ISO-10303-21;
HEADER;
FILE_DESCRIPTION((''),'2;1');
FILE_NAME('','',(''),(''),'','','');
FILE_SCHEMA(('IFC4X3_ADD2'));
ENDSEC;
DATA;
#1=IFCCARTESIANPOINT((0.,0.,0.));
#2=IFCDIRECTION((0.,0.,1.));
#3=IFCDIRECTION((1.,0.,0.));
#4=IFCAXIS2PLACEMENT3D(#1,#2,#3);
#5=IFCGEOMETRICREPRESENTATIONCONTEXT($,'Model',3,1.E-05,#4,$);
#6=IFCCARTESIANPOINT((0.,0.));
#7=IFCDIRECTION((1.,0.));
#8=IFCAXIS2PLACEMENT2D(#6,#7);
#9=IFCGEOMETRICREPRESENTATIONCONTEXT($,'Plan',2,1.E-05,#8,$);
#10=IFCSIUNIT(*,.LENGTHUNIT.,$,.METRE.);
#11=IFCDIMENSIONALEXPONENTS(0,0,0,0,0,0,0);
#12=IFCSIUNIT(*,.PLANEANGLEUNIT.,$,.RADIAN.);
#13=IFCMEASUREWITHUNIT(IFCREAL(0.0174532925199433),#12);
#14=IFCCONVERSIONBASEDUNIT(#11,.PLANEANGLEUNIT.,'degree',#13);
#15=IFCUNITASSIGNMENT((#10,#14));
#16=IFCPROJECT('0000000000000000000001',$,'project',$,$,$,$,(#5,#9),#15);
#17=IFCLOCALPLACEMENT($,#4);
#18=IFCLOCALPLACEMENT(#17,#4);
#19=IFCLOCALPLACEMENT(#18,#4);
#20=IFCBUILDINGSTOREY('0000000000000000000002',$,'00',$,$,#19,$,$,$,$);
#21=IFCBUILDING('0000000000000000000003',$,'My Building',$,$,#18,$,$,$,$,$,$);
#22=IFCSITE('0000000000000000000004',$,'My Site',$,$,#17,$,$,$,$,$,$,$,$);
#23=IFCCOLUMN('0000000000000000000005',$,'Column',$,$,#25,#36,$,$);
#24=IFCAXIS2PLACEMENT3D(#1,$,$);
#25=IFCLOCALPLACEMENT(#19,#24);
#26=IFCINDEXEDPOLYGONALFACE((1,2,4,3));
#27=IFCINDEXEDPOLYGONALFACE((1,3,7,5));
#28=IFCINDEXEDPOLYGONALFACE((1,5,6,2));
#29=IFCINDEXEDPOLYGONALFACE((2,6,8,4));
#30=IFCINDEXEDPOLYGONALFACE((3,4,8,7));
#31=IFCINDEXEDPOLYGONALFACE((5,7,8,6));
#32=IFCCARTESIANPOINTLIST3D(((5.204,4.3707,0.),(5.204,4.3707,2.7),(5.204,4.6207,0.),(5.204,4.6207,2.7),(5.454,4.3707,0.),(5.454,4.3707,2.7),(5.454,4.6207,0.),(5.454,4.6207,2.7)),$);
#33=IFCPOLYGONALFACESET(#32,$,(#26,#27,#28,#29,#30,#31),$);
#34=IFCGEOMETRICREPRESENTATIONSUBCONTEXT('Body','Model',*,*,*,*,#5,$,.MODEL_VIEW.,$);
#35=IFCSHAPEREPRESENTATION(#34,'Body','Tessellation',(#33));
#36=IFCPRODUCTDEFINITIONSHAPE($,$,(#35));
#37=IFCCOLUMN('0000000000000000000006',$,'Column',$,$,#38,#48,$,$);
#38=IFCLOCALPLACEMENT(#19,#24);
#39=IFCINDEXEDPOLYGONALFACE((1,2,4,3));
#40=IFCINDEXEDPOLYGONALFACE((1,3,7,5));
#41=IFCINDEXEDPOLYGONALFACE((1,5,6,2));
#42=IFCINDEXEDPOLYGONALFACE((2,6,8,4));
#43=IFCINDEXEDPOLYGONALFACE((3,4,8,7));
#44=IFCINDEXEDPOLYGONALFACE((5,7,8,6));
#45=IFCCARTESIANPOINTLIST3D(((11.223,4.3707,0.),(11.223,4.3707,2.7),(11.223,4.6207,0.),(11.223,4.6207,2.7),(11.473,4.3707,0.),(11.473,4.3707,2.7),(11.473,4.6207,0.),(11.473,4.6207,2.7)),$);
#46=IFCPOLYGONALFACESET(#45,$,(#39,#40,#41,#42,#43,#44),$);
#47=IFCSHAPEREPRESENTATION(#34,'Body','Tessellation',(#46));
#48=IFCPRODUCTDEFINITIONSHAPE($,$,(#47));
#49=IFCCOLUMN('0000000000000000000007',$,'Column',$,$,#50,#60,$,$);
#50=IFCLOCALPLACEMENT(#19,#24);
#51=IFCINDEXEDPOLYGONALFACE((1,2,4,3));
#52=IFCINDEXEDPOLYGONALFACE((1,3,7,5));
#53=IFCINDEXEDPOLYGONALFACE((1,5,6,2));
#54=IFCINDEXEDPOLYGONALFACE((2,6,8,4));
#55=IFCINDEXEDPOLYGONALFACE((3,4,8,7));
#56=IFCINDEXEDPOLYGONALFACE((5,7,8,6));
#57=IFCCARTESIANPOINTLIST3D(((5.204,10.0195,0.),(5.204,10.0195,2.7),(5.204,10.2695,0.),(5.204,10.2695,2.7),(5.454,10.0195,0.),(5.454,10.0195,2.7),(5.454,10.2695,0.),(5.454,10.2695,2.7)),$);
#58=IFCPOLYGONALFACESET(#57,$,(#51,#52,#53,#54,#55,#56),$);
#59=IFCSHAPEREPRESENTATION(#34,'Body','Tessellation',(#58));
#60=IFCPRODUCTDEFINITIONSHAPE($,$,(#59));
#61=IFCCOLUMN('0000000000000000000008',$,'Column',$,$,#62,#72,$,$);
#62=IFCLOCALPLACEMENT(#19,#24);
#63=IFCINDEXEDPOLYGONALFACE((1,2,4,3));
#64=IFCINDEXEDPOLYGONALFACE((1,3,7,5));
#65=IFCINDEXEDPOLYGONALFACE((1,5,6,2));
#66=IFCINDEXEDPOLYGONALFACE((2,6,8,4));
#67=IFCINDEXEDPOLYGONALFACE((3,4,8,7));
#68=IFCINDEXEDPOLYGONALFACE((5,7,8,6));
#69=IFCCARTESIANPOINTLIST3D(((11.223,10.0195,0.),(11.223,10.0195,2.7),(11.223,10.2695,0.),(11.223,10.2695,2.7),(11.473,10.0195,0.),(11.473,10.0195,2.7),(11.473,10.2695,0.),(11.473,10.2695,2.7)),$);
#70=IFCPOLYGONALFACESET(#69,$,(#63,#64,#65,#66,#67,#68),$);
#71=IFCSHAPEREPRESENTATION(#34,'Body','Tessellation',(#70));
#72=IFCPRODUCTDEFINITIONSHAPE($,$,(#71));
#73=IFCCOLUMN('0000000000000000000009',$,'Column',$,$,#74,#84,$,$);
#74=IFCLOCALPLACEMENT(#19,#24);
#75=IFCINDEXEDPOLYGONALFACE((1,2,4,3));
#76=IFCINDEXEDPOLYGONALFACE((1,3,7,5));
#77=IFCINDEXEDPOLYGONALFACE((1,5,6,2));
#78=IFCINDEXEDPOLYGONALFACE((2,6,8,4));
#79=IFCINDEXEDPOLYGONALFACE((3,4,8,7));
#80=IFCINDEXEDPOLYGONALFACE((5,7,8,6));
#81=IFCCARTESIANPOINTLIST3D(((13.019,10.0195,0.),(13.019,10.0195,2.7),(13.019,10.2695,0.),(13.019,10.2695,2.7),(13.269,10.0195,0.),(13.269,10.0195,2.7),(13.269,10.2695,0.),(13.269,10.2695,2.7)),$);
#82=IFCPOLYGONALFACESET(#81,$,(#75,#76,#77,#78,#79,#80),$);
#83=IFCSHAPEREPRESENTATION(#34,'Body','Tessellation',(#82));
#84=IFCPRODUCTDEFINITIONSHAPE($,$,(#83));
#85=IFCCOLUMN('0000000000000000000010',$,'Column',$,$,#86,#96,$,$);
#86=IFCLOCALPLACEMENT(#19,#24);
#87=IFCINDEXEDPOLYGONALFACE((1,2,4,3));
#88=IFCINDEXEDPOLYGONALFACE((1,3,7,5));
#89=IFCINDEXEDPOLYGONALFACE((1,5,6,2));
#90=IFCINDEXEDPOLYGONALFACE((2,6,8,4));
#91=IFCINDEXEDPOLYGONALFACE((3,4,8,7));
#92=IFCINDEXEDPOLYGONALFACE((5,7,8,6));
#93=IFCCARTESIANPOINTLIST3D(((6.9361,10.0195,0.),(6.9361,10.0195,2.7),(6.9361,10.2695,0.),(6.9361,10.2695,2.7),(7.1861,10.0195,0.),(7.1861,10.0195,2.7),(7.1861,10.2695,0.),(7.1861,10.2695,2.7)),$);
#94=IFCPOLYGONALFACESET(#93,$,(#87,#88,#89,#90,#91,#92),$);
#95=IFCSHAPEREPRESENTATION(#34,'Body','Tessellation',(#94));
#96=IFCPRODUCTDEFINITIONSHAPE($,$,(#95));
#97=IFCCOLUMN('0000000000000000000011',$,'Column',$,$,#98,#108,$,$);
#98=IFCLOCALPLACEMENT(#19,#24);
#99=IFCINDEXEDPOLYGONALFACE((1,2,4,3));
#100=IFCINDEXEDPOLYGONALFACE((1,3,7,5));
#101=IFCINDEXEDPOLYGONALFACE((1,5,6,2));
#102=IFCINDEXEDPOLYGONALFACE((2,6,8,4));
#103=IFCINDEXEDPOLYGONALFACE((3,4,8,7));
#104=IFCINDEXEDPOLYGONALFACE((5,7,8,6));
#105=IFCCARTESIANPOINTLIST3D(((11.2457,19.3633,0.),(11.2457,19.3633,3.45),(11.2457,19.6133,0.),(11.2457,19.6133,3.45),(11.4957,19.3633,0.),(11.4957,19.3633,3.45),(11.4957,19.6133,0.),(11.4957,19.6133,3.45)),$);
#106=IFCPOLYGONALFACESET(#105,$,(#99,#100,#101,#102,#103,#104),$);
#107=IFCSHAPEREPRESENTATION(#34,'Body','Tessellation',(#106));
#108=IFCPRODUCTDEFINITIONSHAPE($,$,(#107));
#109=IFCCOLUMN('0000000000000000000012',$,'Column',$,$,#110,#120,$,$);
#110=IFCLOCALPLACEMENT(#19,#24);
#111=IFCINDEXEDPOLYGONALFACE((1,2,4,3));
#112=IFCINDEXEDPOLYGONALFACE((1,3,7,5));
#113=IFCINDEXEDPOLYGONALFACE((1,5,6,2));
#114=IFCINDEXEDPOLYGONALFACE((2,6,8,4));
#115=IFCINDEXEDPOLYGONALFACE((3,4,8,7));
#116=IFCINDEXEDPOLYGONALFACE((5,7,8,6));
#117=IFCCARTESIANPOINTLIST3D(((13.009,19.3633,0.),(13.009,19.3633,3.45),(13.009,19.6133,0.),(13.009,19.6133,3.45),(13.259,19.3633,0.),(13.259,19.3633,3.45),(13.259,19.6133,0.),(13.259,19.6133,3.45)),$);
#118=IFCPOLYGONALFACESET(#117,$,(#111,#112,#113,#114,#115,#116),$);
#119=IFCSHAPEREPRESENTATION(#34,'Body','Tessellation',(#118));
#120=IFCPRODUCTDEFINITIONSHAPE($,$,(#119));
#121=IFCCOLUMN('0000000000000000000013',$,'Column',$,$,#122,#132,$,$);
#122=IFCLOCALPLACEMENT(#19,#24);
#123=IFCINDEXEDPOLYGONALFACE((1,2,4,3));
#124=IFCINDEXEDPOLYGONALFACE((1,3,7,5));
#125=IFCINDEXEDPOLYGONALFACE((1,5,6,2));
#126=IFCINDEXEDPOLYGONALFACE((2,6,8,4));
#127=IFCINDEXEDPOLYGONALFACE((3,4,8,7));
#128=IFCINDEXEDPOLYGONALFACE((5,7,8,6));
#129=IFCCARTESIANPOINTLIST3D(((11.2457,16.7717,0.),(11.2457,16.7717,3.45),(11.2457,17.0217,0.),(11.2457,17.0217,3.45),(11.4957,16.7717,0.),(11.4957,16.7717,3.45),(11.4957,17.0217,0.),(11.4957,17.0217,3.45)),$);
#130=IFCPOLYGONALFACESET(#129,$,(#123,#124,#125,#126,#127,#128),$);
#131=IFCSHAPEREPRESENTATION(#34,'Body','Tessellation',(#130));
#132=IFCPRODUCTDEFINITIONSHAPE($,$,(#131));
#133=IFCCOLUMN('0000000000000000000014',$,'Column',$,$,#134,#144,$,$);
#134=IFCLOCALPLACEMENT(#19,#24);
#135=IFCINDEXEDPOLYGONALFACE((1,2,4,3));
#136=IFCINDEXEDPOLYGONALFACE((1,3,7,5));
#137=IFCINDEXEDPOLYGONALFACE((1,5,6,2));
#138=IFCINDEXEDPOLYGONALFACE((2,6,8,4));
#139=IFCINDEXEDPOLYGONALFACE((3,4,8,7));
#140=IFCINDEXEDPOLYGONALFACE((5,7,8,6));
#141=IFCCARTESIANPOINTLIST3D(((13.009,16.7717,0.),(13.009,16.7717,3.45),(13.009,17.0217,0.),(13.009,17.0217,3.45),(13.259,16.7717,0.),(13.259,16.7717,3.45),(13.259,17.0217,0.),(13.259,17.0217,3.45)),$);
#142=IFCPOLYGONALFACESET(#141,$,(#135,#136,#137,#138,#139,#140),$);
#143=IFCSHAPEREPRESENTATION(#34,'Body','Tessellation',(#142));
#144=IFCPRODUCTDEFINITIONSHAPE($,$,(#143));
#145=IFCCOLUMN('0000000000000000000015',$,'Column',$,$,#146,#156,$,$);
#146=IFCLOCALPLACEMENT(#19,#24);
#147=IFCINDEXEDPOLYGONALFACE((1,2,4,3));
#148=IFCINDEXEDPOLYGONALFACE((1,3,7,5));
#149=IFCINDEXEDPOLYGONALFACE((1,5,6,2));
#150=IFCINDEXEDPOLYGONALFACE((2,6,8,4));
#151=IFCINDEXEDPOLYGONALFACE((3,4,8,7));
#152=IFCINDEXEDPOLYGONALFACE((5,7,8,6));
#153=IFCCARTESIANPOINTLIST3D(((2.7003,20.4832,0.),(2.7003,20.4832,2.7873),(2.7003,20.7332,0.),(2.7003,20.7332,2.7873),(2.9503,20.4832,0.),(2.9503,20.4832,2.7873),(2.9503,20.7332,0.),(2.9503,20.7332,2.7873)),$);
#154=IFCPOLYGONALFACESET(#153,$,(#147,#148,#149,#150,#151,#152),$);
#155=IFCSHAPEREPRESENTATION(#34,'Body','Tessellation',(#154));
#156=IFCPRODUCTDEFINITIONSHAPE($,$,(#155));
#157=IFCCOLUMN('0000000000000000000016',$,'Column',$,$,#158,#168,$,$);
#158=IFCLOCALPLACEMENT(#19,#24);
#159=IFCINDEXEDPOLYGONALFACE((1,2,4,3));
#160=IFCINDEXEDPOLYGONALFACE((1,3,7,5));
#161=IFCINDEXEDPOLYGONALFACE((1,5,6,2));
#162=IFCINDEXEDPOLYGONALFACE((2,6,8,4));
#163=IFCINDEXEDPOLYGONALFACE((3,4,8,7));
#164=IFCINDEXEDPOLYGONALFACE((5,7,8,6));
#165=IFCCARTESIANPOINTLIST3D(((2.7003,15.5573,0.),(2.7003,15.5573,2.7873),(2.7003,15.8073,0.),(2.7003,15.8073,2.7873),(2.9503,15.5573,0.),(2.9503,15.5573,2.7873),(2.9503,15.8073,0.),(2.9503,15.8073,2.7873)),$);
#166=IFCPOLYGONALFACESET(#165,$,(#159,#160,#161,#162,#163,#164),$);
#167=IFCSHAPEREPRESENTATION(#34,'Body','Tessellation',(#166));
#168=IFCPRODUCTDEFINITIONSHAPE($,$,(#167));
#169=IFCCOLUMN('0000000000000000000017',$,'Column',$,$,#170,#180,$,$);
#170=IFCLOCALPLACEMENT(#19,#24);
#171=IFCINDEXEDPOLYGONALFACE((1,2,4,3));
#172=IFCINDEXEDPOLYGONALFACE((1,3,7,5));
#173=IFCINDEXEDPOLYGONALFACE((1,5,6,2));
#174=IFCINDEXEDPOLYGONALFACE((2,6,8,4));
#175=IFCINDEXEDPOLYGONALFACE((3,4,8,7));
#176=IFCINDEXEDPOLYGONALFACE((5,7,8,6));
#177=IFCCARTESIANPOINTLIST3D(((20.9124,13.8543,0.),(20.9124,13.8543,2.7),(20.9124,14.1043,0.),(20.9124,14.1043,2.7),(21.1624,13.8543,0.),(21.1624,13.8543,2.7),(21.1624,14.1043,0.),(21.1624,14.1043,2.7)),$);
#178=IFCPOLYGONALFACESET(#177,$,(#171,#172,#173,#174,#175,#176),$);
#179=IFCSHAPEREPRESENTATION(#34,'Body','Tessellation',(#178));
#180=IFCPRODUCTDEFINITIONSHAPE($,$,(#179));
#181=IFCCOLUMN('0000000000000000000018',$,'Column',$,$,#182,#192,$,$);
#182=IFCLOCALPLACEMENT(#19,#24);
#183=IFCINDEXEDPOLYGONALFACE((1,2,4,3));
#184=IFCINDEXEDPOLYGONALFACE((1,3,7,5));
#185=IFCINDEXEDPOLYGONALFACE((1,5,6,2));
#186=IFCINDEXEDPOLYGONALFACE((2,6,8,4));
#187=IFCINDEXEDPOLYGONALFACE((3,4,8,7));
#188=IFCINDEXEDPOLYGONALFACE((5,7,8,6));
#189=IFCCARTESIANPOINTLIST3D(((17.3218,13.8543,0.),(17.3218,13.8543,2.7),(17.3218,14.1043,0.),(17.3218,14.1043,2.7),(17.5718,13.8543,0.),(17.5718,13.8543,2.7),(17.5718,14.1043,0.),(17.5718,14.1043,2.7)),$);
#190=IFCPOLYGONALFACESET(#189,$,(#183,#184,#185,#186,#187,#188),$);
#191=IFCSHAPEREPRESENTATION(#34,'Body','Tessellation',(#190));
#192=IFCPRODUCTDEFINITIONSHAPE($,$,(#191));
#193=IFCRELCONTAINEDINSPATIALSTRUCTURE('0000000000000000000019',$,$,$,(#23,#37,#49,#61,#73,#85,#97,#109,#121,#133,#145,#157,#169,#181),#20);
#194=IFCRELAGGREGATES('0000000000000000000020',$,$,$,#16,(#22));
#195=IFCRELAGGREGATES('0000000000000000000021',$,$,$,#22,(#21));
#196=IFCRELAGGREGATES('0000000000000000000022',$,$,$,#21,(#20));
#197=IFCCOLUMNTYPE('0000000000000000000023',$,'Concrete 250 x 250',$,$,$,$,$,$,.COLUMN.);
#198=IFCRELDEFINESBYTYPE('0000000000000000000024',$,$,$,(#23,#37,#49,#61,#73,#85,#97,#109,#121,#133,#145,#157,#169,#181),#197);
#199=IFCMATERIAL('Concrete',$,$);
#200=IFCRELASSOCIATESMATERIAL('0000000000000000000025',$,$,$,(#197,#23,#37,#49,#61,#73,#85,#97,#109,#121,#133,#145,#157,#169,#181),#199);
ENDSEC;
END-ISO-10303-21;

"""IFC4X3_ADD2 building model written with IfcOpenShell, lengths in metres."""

from ifc_helpers import new_model, entity, si_unit, converted_unit, frame, origin_with_axes, origin_2d_with_axis, place, context, subcontext, project, spatial, rectangle, extrude, material, material_profile, profile_set, profile_usage, type_object, element, save


model = new_model("IFC4X3_ADD2")

# Units and contexts
model_context = context("Model", 3, precision=1e-05, world=origin_with_axes())
plan_context = context("Plan", 2, precision=1e-05, world=origin_2d_with_axis())
body_context = subcontext(model_context, "Body", "Model", "MODEL_VIEW")
ifc_project = project(units=[si_unit("LENGTHUNIT", "METRE"), converted_unit("PLANEANGLEUNIT", "degree", entity("IfcReal", 0.0174532925199433), si_unit("PLANEANGLEUNIT", "RADIAN"), dimensions=[0, 0, 0, 0, 0, 0, 0])], contexts=[model_context, plan_context])

# Site, building, storey
site_placement = place(None, origin_with_axes())
site = spatial("IfcSite", under=ifc_project, at=site_placement, Name="My Site")
building_placement = place(site_placement, origin_with_axes())
building = spatial("IfcBuilding", under=site, at=building_placement, Name="My Building")
storey_placement = place(building_placement, origin_with_axes())
storey = spatial("IfcBuildingStorey", under=building, at=storey_placement, Name="00")

# Columns
ifc_material_1 = material(Name="Concrete")
ifc_material_profile = material_profile(ifc_material_1, rectangle(XDim=0.25, YDim=0.25))
ifc_profile_set = profile_set([ifc_material_profile])
ifc_profile_usage_1 = profile_usage(ifc_profile_set, cardinal=5)
column_type = type_object("IfcColumnType", Name="Concrete 250 x 250", PredefinedType="COLUMN", material=ifc_profile_set)
column_1_placement = place(storey_placement, frame((5.329, 4.4957, 0.0), z_axis=(0.0, 0.0, 1.0), x_axis=(1.0, 0.0, 0.0)))
element("IfcColumn", 1, at=column_1_placement, inside=storey, type_object=column_type, material=ifc_profile_usage_1, Name="Column", context=body_context, shape_type="SweptSolid", body=[
    extrude(rectangle(XDim=0.25, YDim=0.25), origin_with_axes(), (0.0, 0.0, 1.0), 2.7),
])
ifc_profile_usage_2 = profile_usage(ifc_profile_set, cardinal=5)
column_2_placement = place(storey_placement, frame((11.348, 4.4957, 0.0), z_axis=(0.0, 0.0, 1.0), x_axis=(1.0, 0.0, 0.0)))
element("IfcColumn", 2, at=column_2_placement, inside=storey, type_object=column_type, material=ifc_profile_usage_2, Name="Column", context=body_context, shape_type="SweptSolid", body=[
    extrude(rectangle(XDim=0.25, YDim=0.25), origin_with_axes(), (0.0, 0.0, 1.0), 2.7),
])
ifc_profile_usage_3 = profile_usage(ifc_profile_set, cardinal=5)
column_3_placement = place(storey_placement, frame((5.329, 10.1445, 0.0), z_axis=(0.0, 0.0, 1.0), x_axis=(1.0, 0.0, 0.0)))
element("IfcColumn", 3, at=column_3_placement, inside=storey, type_object=column_type, material=ifc_profile_usage_3, Name="Column", context=body_context, shape_type="SweptSolid", body=[
    extrude(rectangle(XDim=0.25, YDim=0.25), origin_with_axes(), (0.0, 0.0, 1.0), 2.7),
])
ifc_profile_usage_4 = profile_usage(ifc_profile_set, cardinal=5)
column_4_placement = place(storey_placement, frame((11.348, 10.1445, 0.0), z_axis=(0.0, 0.0, 1.0), x_axis=(1.0, 0.0, 0.0)))
element("IfcColumn", 4, at=column_4_placement, inside=storey, type_object=column_type, material=ifc_profile_usage_4, Name="Column", context=body_context, shape_type="SweptSolid", body=[
    extrude(rectangle(XDim=0.25, YDim=0.25), origin_with_axes(), (0.0, 0.0, 1.0), 2.7),
])
ifc_profile_usage_5 = profile_usage(ifc_profile_set, cardinal=5)
column_5_placement = place(storey_placement, frame((13.144, 10.1445, 0.0), z_axis=(0.0, 0.0, 1.0), x_axis=(1.0, 0.0, 0.0)))
element("IfcColumn", 5, at=column_5_placement, inside=storey, type_object=column_type, material=ifc_profile_usage_5, Name="Column", context=body_context, shape_type="SweptSolid", body=[
    extrude(rectangle(XDim=0.25, YDim=0.25), origin_with_axes(), (0.0, 0.0, 1.0), 2.7),
])
ifc_profile_usage_6 = profile_usage(ifc_profile_set, cardinal=5)
column_6_placement = place(storey_placement, frame((7.0611, 10.1445, 0.0), z_axis=(0.0, 0.0, 1.0), x_axis=(1.0, 0.0, 0.0)))
element("IfcColumn", 6, at=column_6_placement, inside=storey, type_object=column_type, material=ifc_profile_usage_6, Name="Column", context=body_context, shape_type="SweptSolid", body=[
    extrude(rectangle(XDim=0.25, YDim=0.25), origin_with_axes(), (0.0, 0.0, 1.0), 2.7),
])
ifc_profile_usage_7 = profile_usage(ifc_profile_set, cardinal=5)
column_7_placement = place(storey_placement, frame((11.3707, 19.4883, 0.0), z_axis=(0.0, 0.0, 1.0), x_axis=(1.0, 0.0, 0.0)))
element("IfcColumn", 7, at=column_7_placement, inside=storey, type_object=column_type, material=ifc_profile_usage_7, Name="Column", context=body_context, shape_type="SweptSolid", body=[
    extrude(rectangle(XDim=0.25, YDim=0.25), origin_with_axes(), (0.0, 0.0, 1.0), 3.45),
])
ifc_profile_usage_8 = profile_usage(ifc_profile_set, cardinal=5)
column_8_placement = place(storey_placement, frame((13.134, 19.4883, 0.0), z_axis=(0.0, 0.0, 1.0), x_axis=(1.0, 0.0, 0.0)))
element("IfcColumn", 8, at=column_8_placement, inside=storey, type_object=column_type, material=ifc_profile_usage_8, Name="Column", context=body_context, shape_type="SweptSolid", body=[
    extrude(rectangle(XDim=0.25, YDim=0.25), origin_with_axes(), (0.0, 0.0, 1.0), 3.45),
])
ifc_profile_usage_9 = profile_usage(ifc_profile_set, cardinal=5)
column_9_placement = place(storey_placement, frame((11.3707, 16.8967, 0.0), z_axis=(0.0, 0.0, 1.0), x_axis=(1.0, 0.0, 0.0)))
element("IfcColumn", 9, at=column_9_placement, inside=storey, type_object=column_type, material=ifc_profile_usage_9, Name="Column", context=body_context, shape_type="SweptSolid", body=[
    extrude(rectangle(XDim=0.25, YDim=0.25), origin_with_axes(), (0.0, 0.0, 1.0), 3.45),
])
ifc_profile_usage_10 = profile_usage(ifc_profile_set, cardinal=5)
column_10_placement = place(storey_placement, frame((13.134, 16.8967, 0.0), z_axis=(0.0, 0.0, 1.0), x_axis=(1.0, 0.0, 0.0)))
element("IfcColumn", 10, at=column_10_placement, inside=storey, type_object=column_type, material=ifc_profile_usage_10, Name="Column", context=body_context, shape_type="SweptSolid", body=[
    extrude(rectangle(XDim=0.25, YDim=0.25), origin_with_axes(), (0.0, 0.0, 1.0), 3.45),
])
ifc_profile_usage_11 = profile_usage(ifc_profile_set, cardinal=5)
column_11_placement = place(storey_placement, frame((2.8253, 20.6082, 0.0), z_axis=(0.0, 0.0, 1.0), x_axis=(1.0, 0.0, 0.0)))
element("IfcColumn", 11, at=column_11_placement, inside=storey, type_object=column_type, material=ifc_profile_usage_11, Name="Column", context=body_context, shape_type="SweptSolid", body=[
    extrude(rectangle(XDim=0.25, YDim=0.25), origin_with_axes(), (0.0, 0.0, 1.0), 2.7873),
])
ifc_profile_usage_12 = profile_usage(ifc_profile_set, cardinal=5)
column_12_placement = place(storey_placement, frame((2.8253, 15.6823, 0.0), z_axis=(0.0, 0.0, 1.0), x_axis=(1.0, 0.0, 0.0)))
element("IfcColumn", 12, at=column_12_placement, inside=storey, type_object=column_type, material=ifc_profile_usage_12, Name="Column", context=body_context, shape_type="SweptSolid", body=[
    extrude(rectangle(XDim=0.25, YDim=0.25), origin_with_axes(), (0.0, 0.0, 1.0), 2.7873),
])
ifc_profile_usage_13 = profile_usage(ifc_profile_set, cardinal=5)
column_13_placement = place(storey_placement, frame((21.0374, 13.9793, 0.0), z_axis=(0.0, 0.0, 1.0), x_axis=(1.0, 0.0, 0.0)))
element("IfcColumn", 13, at=column_13_placement, inside=storey, type_object=column_type, material=ifc_profile_usage_13, Name="Column", context=body_context, shape_type="SweptSolid", body=[
    extrude(rectangle(XDim=0.25, YDim=0.25), origin_with_axes(), (0.0, 0.0, 1.0), 2.7),
])
ifc_profile_usage_14 = profile_usage(ifc_profile_set, cardinal=5)
column_14_placement = place(storey_placement, frame((17.4468, 13.9793, 0.0), z_axis=(0.0, 0.0, 1.0), x_axis=(1.0, 0.0, 0.0)))
element("IfcColumn", 14, at=column_14_placement, inside=storey, type_object=column_type, material=ifc_profile_usage_14, Name="Column", context=body_context, shape_type="SweptSolid", body=[
    extrude(rectangle(XDim=0.25, YDim=0.25), origin_with_axes(), (0.0, 0.0, 1.0), 2.7),
])

save(model, "model.ifc")
